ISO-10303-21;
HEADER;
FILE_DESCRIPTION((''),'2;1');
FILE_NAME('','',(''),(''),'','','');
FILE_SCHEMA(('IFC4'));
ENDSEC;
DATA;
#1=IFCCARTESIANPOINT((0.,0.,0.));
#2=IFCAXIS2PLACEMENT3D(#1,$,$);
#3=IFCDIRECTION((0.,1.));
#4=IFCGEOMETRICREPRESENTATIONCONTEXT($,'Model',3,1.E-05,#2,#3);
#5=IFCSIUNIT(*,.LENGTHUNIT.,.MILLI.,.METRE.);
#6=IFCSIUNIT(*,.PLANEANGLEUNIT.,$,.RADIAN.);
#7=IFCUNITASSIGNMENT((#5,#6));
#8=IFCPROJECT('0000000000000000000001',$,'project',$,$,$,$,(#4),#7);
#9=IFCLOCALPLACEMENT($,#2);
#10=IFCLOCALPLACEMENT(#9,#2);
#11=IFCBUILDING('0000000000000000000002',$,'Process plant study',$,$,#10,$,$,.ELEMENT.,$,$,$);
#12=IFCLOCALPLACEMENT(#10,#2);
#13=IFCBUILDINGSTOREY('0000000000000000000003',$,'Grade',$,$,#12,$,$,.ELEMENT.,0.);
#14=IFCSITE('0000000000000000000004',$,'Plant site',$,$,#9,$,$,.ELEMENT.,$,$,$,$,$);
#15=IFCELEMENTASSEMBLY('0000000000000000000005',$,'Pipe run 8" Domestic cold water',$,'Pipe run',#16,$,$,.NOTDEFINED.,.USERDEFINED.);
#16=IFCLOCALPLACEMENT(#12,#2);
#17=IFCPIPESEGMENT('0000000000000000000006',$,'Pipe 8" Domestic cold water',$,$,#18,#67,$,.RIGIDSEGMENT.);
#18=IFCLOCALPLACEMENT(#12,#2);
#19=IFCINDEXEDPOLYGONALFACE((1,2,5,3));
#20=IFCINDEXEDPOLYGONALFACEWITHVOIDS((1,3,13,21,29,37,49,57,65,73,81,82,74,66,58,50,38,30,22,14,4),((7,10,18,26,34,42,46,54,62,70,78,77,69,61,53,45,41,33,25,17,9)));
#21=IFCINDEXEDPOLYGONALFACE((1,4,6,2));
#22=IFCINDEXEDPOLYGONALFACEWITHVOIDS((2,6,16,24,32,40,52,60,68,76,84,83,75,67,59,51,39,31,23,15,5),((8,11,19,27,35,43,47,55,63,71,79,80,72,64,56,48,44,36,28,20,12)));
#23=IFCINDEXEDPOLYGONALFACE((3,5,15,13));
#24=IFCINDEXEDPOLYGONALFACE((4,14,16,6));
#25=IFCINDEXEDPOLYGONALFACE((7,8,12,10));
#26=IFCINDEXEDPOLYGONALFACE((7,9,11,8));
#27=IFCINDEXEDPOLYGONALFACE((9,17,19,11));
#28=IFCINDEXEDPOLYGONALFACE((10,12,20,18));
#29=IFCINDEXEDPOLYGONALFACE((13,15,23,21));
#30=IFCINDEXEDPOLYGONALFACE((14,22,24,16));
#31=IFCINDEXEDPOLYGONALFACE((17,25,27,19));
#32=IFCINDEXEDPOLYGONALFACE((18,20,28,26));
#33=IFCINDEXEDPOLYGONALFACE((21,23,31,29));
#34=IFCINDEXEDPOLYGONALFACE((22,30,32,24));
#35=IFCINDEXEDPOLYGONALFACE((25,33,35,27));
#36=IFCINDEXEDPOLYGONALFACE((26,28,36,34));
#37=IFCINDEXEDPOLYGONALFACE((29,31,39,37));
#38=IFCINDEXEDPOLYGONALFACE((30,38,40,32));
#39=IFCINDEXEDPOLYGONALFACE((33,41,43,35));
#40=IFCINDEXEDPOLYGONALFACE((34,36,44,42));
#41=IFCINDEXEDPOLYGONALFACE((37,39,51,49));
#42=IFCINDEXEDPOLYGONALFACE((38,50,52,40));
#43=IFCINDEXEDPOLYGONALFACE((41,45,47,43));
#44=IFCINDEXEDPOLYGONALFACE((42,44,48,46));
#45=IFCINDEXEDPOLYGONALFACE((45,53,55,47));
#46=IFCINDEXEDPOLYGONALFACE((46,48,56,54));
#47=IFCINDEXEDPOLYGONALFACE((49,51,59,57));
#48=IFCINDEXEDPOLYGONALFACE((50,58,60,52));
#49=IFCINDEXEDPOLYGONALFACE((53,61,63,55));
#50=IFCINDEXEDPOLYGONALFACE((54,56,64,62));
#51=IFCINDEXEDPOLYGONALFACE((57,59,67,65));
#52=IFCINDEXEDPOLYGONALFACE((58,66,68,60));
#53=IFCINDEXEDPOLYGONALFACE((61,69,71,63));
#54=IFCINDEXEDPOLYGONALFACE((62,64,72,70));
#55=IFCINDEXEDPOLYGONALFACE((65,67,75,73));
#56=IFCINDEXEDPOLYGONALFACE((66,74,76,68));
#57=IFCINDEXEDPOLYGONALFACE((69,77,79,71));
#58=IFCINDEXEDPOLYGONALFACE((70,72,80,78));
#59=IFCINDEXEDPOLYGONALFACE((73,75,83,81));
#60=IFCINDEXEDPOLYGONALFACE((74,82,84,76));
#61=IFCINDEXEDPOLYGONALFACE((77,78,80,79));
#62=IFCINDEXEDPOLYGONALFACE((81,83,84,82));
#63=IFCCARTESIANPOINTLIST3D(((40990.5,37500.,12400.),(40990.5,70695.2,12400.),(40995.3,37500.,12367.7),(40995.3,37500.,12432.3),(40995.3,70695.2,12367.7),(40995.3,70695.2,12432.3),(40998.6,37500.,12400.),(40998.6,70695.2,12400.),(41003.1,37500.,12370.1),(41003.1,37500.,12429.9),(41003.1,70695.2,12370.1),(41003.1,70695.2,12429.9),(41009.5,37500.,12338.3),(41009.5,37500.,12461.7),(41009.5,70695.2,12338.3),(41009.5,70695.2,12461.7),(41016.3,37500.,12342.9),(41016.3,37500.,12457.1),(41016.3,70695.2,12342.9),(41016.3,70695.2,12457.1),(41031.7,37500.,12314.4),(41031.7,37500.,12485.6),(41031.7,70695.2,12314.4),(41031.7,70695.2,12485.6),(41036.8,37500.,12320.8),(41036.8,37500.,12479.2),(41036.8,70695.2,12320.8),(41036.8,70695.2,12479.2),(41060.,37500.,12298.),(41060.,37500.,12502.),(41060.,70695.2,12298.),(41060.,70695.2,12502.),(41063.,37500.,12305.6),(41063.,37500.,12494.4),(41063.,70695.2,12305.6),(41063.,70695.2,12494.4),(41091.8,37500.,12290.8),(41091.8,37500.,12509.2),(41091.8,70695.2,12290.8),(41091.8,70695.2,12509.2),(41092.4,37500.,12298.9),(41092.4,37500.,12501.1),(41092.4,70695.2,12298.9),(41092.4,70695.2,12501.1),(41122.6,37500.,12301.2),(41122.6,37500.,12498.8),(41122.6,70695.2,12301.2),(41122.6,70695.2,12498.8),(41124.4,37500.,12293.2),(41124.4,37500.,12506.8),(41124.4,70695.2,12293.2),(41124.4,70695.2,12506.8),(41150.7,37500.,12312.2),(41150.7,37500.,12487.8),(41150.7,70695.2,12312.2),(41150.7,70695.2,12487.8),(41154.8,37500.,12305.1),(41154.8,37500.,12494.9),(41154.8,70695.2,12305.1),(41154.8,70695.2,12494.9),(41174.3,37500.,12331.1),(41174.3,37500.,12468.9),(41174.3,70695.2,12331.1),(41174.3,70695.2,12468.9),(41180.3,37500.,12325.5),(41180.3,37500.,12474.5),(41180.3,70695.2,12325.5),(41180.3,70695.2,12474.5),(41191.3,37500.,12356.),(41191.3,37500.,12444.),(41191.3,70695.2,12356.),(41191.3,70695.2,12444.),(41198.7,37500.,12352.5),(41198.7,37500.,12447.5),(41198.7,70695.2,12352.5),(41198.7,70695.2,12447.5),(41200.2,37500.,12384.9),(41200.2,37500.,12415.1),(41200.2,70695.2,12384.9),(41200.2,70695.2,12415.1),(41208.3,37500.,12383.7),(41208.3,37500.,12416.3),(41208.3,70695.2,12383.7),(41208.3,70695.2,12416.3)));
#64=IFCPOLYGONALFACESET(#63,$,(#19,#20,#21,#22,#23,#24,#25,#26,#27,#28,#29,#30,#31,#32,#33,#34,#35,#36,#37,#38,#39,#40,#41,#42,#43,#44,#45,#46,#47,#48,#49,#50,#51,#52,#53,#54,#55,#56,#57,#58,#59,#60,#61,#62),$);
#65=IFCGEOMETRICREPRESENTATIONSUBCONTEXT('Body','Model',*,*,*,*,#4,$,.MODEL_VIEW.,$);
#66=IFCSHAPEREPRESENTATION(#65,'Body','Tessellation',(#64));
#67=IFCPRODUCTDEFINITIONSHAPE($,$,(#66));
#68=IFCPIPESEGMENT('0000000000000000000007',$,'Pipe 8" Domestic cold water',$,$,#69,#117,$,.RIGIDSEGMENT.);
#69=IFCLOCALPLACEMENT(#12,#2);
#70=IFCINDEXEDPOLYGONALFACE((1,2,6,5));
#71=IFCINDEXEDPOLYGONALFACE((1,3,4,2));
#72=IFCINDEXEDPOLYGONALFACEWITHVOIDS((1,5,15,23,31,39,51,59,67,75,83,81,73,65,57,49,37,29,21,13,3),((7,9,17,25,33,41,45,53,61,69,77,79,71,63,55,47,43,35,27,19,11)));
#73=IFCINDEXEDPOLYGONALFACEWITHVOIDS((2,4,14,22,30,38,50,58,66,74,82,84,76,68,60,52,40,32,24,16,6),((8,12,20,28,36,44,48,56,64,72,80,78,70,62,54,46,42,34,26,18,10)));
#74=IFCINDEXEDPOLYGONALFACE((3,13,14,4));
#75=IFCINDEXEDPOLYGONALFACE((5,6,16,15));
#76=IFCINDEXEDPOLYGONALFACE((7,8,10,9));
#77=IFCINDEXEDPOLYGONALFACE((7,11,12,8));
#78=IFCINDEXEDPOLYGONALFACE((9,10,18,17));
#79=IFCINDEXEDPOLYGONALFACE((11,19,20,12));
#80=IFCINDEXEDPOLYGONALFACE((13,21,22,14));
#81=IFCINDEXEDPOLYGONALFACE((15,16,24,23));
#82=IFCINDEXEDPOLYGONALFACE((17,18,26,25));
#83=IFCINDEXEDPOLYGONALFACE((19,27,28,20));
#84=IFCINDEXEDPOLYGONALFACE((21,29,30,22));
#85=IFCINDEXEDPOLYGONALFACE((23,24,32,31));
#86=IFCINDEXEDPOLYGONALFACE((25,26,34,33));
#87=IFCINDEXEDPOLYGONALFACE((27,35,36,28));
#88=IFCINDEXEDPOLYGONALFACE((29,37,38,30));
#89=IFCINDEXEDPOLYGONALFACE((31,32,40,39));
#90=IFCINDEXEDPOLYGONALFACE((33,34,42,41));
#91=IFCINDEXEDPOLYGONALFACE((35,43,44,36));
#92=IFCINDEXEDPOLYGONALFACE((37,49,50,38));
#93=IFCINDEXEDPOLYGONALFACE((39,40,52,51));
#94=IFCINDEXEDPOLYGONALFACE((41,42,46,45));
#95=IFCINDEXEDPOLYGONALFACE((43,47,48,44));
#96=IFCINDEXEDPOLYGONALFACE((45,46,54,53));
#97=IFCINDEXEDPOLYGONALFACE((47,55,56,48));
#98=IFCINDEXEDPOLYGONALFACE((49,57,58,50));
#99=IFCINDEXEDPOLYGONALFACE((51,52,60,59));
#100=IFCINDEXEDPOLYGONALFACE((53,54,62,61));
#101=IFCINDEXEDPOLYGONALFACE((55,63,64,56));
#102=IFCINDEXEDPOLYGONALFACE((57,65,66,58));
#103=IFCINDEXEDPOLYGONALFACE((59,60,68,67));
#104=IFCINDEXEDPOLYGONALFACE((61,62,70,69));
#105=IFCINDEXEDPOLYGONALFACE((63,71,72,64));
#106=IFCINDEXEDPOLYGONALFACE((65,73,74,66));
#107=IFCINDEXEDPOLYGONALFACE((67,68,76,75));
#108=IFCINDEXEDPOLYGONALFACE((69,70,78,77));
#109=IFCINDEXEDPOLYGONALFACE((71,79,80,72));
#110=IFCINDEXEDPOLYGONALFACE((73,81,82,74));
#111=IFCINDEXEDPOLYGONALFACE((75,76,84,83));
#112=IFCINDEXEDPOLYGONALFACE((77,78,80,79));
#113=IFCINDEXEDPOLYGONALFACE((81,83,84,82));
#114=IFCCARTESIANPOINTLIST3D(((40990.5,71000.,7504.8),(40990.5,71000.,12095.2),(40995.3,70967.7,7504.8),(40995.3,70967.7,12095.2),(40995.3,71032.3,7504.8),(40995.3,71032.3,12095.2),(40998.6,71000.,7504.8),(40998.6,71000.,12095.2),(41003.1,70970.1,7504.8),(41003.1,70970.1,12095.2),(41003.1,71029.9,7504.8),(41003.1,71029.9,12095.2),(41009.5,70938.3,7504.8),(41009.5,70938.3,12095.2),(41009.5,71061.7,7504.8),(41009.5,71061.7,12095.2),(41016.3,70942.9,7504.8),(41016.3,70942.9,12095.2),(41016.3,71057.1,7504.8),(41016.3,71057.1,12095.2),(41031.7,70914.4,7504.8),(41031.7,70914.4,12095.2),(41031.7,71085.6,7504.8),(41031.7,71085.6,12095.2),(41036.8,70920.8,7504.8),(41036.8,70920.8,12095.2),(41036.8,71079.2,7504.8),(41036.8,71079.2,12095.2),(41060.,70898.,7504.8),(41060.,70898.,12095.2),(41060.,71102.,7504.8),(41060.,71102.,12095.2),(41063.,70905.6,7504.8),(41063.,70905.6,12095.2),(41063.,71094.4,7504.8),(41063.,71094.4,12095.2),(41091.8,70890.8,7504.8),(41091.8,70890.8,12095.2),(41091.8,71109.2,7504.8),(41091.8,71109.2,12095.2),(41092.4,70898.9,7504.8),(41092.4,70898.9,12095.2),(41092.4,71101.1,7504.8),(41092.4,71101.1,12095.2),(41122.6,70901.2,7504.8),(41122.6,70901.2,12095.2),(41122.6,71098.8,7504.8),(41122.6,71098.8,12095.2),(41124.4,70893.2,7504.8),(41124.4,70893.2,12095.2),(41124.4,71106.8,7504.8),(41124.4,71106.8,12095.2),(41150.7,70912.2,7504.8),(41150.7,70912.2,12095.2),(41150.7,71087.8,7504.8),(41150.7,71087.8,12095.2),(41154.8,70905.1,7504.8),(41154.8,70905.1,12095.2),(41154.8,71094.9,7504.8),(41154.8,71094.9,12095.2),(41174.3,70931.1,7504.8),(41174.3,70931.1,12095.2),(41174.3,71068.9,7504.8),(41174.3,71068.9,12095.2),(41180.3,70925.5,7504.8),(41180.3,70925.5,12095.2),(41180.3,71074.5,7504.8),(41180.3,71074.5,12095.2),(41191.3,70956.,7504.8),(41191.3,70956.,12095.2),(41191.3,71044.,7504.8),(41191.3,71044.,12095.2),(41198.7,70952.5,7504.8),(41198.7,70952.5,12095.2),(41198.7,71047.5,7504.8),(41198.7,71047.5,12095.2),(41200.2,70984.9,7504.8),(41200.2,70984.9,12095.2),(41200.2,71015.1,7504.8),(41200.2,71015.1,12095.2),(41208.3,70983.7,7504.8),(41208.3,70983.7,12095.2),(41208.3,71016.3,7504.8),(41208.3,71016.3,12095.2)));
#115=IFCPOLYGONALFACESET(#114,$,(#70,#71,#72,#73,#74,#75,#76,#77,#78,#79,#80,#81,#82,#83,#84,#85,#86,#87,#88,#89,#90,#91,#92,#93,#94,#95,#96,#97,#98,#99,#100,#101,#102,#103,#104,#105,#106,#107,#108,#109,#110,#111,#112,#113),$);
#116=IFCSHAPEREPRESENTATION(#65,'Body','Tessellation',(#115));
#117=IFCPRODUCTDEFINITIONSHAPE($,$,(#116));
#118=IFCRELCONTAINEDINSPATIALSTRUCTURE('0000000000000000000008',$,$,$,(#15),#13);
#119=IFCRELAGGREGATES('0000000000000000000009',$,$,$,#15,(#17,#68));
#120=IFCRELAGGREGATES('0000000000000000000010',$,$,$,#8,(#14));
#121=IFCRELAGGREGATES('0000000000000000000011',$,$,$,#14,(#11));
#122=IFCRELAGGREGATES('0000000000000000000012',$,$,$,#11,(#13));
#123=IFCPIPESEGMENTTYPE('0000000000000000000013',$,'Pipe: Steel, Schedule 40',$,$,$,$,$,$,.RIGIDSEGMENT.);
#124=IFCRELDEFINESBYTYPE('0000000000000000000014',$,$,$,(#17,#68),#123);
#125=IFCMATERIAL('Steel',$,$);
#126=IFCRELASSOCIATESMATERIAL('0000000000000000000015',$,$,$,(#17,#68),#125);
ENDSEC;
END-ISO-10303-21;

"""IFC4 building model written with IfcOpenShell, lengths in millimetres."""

from ifc_helpers import new_model, si_unit, direction, frame, origin, origin_with_axes, origin_2d, place, context, subcontext, project, spatial, hollow_circle, extrude, material, type_object, element, aggregate, save


model = new_model("IFC4")

# Units and contexts
model_context = context("Model", 3, precision=1e-05, world=origin(), true_north=direction((0.0, 1.0)))
body_context = subcontext(model_context, "Body", "Model", "MODEL_VIEW")
ifc_project = project(units=[si_unit("LENGTHUNIT", "METRE", prefix="MILLI"), si_unit("PLANEANGLEUNIT", "RADIAN")], contexts=[model_context])

# Site, building, storey
site_placement = place(None, origin())
site = spatial("IfcSite", under=ifc_project, at=site_placement, Name="Plant site", CompositionType="ELEMENT")
building_placement = place(site_placement, origin())
building = spatial("IfcBuilding", under=site, at=building_placement, Name="Process plant study", CompositionType="ELEMENT")
storey_placement = place(building_placement, origin())
storey = spatial("IfcBuildingStorey", under=building, at=storey_placement, Name="Grade", CompositionType="ELEMENT", Elevation=0.0)

# Shared definitions
ifc_material = material(Name="Steel")
pipe_segment_type = type_object("IfcPipeSegmentType", Name="Pipe: Steel, Schedule 40", PredefinedType="RIGIDSEGMENT")

# Element assembly, pipe segments
assembly_1_placement = place(storey_placement, origin_with_axes())
assembly_1 = element("IfcElementAssembly", 1, at=assembly_1_placement, inside=storey, Name="Pipe run 8\" Domestic cold water", ObjectType="Pipe run", AssemblyPlace="NOTDEFINED", PredefinedType="USERDEFINED")
pipe_segment_1_placement = place(storey_placement, origin_with_axes())
pipe_segment_1 = element("IfcPipeSegment", 2, at=pipe_segment_1_placement, type_object=pipe_segment_type, material=ifc_material, Name="Pipe 8\" Domestic cold water", PredefinedType="RIGIDSEGMENT", context=body_context, shape_type="SweptSolid", body=[
    extrude(hollow_circle(Radius=109.5, WallThickness=8.2, at=origin_2d()), frame((41100.0, 37500.0, 12400.0), z_axis=(0.0, 1.0, 0.0), x_axis=(-1.0, 0.0, 0.0)), (0.0, 0.0, 1.0), 33195.2),
])
pipe_segment_2_placement = place(storey_placement, origin_with_axes())
pipe_segment_2 = element("IfcPipeSegment", 3, at=pipe_segment_2_placement, type_object=pipe_segment_type, material=ifc_material, Name="Pipe 8\" Domestic cold water", PredefinedType="RIGIDSEGMENT", context=body_context, shape_type="SweptSolid", body=[
    extrude(hollow_circle(Radius=109.5, WallThickness=8.2, at=origin_2d()), frame((41100.0, 71000.0, 12095.2), z_axis=(0.0, 0.0, -1.0), x_axis=(-1.0, 0.0, 0.0)), (0.0, 0.0, 1.0), 4590.4),
])

aggregate(assembly_1, [pipe_segment_1, pipe_segment_2])

save(model, "model.ifc")
